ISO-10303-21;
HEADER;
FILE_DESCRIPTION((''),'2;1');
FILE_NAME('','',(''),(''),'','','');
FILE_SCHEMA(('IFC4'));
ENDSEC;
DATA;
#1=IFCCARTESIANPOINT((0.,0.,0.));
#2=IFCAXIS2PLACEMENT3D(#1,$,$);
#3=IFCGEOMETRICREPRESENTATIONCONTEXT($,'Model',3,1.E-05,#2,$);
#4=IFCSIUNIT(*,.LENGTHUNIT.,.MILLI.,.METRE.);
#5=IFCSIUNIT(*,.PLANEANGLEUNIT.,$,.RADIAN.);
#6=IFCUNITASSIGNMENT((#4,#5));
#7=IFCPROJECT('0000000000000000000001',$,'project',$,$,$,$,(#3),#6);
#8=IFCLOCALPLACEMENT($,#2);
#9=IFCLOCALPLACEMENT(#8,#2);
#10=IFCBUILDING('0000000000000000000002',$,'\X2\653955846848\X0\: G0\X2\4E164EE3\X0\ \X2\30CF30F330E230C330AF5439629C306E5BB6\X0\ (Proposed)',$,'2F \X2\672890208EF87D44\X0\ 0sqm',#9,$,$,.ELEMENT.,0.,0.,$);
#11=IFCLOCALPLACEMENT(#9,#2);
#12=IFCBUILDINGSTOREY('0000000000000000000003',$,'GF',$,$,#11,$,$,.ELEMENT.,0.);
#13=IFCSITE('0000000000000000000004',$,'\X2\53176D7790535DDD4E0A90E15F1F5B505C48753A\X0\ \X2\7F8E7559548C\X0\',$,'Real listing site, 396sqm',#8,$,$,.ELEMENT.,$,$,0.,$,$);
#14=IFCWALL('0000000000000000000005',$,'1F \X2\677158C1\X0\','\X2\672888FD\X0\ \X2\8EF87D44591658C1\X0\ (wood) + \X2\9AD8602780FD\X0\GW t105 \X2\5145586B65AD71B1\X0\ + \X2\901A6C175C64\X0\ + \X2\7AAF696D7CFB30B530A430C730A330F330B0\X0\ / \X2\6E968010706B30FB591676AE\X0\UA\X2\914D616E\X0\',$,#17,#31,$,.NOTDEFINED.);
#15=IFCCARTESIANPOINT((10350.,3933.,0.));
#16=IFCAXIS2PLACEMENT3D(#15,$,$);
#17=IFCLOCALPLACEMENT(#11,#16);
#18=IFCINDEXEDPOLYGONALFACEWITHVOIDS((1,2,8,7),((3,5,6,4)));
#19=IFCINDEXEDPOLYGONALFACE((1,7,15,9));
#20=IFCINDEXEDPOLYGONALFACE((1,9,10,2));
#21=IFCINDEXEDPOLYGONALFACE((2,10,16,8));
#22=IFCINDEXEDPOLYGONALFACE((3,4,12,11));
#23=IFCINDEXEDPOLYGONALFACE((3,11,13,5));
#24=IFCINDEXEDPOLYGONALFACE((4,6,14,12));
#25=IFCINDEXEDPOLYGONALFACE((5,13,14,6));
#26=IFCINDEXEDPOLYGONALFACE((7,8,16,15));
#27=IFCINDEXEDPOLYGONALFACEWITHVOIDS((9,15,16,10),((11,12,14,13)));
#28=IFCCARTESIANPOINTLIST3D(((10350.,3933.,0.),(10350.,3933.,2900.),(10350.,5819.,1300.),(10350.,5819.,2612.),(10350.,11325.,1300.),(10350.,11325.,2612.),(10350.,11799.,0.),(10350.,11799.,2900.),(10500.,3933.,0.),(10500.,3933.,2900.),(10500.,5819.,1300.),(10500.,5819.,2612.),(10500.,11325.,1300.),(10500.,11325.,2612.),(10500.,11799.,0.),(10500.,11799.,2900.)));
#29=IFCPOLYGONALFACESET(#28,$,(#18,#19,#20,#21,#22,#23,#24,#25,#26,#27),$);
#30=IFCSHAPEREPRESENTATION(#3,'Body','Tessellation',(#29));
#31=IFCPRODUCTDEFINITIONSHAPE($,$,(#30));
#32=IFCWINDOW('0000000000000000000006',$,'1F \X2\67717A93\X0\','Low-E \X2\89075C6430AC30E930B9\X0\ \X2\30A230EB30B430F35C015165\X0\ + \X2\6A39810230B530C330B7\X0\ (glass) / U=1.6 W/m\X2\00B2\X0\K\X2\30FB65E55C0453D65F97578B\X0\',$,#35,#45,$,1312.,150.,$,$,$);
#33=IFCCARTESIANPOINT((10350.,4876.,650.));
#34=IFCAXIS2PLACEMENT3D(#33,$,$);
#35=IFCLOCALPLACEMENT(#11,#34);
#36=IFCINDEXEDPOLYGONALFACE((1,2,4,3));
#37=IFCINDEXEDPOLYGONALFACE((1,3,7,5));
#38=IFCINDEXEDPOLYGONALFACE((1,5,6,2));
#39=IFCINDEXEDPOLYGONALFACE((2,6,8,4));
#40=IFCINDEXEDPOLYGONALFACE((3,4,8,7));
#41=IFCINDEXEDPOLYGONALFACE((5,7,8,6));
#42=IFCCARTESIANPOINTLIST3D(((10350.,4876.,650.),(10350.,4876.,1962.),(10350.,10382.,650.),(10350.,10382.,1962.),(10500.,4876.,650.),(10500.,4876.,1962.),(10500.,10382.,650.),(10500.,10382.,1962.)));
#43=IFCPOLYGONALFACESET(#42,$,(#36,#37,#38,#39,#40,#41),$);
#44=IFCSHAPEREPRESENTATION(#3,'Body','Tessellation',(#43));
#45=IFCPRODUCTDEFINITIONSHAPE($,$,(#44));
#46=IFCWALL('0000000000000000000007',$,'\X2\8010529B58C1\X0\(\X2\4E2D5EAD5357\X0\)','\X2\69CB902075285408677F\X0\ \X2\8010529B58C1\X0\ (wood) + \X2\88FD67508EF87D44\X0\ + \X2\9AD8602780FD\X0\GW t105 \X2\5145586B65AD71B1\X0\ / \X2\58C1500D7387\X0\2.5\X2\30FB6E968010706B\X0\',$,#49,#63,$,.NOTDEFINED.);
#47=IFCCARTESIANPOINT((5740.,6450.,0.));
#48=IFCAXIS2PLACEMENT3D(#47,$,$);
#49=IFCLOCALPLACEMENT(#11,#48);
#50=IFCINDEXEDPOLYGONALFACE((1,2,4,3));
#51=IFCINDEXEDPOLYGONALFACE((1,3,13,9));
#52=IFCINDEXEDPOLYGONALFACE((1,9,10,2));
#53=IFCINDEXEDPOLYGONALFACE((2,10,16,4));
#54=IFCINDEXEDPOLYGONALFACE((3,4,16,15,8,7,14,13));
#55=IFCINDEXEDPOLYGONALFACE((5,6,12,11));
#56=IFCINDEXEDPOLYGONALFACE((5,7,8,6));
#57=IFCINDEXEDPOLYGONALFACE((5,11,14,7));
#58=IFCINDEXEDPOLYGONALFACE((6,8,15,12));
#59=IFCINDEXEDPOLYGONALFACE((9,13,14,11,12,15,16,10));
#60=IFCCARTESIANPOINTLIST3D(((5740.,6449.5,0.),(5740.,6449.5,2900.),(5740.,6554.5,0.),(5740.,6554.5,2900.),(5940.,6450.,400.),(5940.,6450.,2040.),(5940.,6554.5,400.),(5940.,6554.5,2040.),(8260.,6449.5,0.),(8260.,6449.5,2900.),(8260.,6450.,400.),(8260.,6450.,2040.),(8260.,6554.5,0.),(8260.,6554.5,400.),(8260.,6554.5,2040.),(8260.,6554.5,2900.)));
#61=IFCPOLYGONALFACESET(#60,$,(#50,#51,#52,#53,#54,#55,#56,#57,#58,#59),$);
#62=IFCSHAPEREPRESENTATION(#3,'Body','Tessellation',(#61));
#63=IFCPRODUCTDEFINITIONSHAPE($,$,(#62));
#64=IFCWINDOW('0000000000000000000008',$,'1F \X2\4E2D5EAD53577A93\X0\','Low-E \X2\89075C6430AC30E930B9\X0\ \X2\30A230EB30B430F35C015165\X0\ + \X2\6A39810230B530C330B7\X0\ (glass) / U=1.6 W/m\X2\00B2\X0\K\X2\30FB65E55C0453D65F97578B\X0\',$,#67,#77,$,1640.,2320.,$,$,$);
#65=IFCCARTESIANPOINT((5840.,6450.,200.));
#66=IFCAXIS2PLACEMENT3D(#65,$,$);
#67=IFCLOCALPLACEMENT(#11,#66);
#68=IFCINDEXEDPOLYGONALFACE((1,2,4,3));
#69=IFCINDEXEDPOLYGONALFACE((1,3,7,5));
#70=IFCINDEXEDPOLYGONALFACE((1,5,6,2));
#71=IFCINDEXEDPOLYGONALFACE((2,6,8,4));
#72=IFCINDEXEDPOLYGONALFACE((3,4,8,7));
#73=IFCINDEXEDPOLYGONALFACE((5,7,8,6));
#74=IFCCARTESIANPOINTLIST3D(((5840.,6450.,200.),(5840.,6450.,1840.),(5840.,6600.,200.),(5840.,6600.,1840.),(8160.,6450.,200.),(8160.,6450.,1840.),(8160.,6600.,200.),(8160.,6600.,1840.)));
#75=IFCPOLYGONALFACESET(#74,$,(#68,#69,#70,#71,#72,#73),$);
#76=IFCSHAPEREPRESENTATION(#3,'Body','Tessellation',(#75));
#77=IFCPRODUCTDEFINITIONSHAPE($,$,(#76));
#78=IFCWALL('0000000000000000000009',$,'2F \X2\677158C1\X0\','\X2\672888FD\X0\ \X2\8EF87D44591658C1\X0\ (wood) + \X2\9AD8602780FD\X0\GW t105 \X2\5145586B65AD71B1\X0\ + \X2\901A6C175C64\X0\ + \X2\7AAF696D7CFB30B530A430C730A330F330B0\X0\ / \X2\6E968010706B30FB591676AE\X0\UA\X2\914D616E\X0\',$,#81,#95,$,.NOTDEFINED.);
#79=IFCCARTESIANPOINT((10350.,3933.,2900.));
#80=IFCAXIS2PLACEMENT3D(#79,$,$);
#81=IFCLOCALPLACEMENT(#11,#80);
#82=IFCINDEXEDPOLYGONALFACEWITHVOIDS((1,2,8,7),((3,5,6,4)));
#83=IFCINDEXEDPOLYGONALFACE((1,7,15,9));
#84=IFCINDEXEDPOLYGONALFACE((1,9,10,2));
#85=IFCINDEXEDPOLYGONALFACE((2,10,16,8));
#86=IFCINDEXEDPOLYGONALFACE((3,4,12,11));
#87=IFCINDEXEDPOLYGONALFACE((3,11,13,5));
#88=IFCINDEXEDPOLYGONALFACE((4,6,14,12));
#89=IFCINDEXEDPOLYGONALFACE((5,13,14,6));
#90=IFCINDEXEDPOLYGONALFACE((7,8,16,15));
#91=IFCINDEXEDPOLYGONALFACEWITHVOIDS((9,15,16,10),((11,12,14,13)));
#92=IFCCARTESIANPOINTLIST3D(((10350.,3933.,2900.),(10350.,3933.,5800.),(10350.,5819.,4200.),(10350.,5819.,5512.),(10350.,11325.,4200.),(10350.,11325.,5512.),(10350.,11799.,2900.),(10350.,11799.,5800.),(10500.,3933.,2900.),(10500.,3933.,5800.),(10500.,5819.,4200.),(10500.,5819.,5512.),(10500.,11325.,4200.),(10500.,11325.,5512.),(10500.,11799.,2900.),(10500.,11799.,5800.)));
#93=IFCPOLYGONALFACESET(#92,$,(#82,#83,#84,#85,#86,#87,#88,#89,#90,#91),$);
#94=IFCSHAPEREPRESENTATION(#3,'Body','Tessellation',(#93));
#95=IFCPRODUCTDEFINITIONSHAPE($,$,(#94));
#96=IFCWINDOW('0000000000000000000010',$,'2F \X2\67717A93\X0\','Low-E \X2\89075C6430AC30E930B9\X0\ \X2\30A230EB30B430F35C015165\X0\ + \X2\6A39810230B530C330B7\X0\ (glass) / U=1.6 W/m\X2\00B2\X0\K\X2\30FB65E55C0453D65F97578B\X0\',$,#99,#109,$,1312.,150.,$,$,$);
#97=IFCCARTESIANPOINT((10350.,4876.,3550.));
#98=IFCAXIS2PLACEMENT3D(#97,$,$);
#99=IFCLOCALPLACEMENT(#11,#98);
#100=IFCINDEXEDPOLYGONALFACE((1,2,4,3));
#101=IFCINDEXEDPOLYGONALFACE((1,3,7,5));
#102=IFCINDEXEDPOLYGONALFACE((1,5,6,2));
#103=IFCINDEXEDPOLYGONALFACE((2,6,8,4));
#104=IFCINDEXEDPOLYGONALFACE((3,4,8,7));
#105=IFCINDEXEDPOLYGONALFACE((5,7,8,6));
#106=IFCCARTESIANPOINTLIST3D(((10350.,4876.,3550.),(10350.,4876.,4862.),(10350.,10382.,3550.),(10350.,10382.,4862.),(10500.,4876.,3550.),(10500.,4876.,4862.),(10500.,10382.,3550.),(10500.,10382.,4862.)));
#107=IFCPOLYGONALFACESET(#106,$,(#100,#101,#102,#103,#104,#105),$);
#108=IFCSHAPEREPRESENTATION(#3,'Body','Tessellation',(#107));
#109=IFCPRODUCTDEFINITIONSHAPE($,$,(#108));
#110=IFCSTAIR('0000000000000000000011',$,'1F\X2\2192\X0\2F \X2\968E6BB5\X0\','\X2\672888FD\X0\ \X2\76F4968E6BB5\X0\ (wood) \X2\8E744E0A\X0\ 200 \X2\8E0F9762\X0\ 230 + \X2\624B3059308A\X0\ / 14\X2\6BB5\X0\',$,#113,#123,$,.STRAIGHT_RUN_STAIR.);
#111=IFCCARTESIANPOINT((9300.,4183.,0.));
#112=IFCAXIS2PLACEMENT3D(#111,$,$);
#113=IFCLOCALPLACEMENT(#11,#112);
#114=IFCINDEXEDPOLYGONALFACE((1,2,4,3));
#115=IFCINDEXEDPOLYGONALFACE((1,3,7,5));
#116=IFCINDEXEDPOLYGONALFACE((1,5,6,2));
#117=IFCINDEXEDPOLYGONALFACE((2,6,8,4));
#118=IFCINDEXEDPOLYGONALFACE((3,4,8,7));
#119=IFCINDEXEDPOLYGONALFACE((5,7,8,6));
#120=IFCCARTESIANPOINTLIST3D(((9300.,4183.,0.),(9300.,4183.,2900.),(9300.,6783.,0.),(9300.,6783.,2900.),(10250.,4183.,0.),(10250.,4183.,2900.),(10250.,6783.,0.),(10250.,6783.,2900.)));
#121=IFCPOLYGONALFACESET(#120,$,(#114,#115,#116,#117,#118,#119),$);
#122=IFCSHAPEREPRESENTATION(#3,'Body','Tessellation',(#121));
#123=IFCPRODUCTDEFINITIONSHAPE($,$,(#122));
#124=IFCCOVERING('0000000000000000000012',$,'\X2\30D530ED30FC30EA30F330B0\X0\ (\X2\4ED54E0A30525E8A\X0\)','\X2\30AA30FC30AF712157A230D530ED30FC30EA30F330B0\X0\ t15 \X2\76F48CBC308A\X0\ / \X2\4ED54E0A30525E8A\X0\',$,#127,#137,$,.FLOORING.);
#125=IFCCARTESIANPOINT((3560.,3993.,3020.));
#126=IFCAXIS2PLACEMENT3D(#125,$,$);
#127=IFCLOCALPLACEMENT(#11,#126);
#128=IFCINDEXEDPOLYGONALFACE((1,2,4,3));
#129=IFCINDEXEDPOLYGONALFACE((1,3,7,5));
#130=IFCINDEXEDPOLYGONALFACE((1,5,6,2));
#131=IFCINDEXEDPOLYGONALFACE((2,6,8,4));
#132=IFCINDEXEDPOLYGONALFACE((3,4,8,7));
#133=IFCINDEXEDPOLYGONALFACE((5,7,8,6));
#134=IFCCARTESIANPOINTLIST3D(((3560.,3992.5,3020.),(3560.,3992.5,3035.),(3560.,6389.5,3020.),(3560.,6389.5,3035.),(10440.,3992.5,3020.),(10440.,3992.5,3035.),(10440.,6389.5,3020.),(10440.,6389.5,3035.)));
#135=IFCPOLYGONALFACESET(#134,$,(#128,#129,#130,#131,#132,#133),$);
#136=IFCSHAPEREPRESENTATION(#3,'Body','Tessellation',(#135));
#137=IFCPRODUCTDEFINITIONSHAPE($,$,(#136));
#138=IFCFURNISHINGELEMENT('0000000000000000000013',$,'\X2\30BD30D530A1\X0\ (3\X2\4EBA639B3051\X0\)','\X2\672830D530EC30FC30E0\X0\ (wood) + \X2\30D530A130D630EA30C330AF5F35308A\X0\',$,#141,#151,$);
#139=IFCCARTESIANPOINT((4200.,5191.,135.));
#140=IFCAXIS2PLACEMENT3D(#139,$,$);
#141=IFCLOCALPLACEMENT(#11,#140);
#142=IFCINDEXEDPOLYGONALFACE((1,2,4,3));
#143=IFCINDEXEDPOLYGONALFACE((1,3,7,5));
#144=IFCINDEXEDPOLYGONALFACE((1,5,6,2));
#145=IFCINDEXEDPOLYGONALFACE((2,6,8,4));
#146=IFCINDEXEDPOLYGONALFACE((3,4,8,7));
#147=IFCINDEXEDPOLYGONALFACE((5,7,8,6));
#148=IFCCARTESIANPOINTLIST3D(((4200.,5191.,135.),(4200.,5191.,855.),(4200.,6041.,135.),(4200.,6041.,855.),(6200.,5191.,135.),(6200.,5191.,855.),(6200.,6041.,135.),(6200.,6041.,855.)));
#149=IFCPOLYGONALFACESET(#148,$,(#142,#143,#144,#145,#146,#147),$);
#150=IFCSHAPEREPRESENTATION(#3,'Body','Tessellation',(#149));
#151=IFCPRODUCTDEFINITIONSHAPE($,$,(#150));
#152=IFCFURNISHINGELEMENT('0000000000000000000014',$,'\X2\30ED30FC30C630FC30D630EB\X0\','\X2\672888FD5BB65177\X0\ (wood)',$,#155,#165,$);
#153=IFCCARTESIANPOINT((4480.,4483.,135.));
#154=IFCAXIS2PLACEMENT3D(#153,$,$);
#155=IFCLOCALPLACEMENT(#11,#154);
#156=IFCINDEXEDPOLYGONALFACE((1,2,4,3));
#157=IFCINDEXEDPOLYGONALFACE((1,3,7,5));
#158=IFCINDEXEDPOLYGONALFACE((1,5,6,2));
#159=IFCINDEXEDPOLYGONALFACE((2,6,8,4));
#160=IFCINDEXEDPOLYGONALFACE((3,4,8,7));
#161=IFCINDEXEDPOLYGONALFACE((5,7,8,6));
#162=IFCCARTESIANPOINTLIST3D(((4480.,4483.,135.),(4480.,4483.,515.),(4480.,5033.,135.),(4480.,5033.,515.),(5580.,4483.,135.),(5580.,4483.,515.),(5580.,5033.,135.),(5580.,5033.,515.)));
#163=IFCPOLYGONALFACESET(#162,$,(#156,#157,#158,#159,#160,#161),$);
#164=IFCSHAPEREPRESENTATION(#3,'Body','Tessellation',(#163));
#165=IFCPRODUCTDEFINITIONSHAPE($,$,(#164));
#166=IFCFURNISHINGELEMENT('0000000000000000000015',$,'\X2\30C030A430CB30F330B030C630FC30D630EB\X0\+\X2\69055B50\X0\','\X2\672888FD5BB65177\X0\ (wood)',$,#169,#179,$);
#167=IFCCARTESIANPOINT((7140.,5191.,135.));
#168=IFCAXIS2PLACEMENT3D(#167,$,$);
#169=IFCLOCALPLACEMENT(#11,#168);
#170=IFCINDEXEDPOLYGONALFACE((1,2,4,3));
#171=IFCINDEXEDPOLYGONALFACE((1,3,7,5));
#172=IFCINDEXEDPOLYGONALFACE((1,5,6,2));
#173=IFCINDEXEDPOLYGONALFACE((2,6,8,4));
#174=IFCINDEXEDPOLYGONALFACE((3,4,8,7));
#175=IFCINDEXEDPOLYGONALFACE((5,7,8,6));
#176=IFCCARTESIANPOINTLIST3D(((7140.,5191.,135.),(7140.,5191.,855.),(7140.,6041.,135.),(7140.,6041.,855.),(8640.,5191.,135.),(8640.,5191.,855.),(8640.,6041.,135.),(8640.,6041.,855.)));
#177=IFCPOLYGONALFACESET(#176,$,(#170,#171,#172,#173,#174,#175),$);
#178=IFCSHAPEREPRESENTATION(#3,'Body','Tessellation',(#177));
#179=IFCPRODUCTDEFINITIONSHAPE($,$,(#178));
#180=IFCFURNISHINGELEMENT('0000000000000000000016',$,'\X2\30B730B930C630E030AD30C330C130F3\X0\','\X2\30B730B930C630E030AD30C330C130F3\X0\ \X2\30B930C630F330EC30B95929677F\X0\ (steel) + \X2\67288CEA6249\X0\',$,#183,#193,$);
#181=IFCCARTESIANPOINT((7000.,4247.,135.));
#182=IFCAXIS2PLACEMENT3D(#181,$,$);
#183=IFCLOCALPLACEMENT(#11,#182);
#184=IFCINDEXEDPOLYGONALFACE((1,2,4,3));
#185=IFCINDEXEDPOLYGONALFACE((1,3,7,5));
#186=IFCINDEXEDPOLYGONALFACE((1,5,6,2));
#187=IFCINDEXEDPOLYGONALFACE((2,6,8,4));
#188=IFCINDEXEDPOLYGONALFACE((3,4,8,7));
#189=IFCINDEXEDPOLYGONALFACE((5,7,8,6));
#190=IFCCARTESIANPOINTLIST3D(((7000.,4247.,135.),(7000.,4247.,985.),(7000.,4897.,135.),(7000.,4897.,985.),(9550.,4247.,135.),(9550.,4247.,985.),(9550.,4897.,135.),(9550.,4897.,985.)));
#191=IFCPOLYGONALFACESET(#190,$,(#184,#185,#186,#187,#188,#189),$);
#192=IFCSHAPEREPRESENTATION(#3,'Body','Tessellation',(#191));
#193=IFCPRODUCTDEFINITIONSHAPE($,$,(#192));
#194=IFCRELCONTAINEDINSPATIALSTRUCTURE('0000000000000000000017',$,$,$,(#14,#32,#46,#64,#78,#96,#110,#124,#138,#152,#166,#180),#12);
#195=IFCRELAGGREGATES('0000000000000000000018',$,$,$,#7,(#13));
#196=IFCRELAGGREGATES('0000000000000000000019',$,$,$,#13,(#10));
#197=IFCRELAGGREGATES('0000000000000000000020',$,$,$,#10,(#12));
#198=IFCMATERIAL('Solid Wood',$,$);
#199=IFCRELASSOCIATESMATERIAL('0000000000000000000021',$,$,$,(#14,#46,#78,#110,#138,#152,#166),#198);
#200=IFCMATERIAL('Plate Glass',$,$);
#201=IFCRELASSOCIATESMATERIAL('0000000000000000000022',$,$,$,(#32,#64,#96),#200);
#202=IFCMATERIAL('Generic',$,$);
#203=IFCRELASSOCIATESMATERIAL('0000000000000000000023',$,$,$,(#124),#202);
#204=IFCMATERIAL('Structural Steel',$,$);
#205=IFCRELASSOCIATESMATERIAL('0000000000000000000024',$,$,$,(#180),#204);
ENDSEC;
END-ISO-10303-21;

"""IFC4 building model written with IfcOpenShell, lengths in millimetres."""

from ifc_helpers import new_model, si_unit, frame, frame_2d, origin, place, context, project, spatial, rectangle, extrude, material, element, fill, save


model = new_model("IFC4")

# Units and contexts
model_context = context("Model", 3, precision=1e-05, world=origin())
ifc_project = project(units=[si_unit("LENGTHUNIT", "METRE", prefix="MILLI"), si_unit("PLANEANGLEUNIT", "RADIAN")], contexts=[model_context])

# Site, building, storey
site_placement = place(None, origin())
site = spatial("IfcSite", under=ifc_project, at=site_placement, Name="北海道川上郡弟子屈町 美留和", ObjectType="Real listing site, 396sqm", CompositionType="ELEMENT", RefElevation=0.0)
building_placement = place(site_placement, origin())
building = spatial("IfcBuilding", under=site, at=building_placement, Name="改善案: G0世代 ハンモック吹抜の家 (Proposed)", ObjectType="2F 木造軸組 0sqm", CompositionType="ELEMENT", ElevationOfRefHeight=0.0, ElevationOfTerrain=0.0)
storey_placement = place(building_placement, origin())
storey = spatial("IfcBuildingStorey", under=building, at=storey_placement, Name="GF", CompositionType="ELEMENT", Elevation=0.0)

# Shared definitions
ifc_material_1 = material(Name="Solid Wood")

# Walls, openings, windows
wall_1_placement = place(storey_placement, frame((10350.0, 3933.0, 0.0)))
wall_1 = element("IfcWall", 1, at=wall_1_placement, inside=storey, material=ifc_material_1, Name="1F 東壁", Description="木製 軸組外壁 (wood) + 高性能GW t105 充填断熱 + 通気層 + 窯業系サイディング / 準耐火・外皮UA配慮", PredefinedType="NOTDEFINED", context=model_context, shape_type="SweptSolid", body=[
    extrude(rectangle(XDim=150.0, YDim=7866.0, at=frame_2d((75.0, 3933.0))), frame((10350.0, 3933.0, 0.0)), (0.0, 0.0, 1.0), 2900.0),
])
opening_1_placement = place(storey_placement, frame((10350.0, 4876.0, 650.0)))
opening_1 = element("IfcOpeningElement", 2, at=opening_1_placement, cuts=wall_1, PredefinedType="NOTDEFINED", context=model_context, shape_type="SweptSolid", body=[
    extrude(rectangle(XDim=150.0, YDim=5506.0, at=frame_2d((75.0, 2753.0))), frame((10350.0, 4876.0, 650.0)), (0.0, 0.0, 1.0), 1312.0),
])
ifc_material_2 = material(Name="Plate Glass")
window_1_placement = place(storey_placement, frame((10350.0, 4876.0, 650.0)))
window_1 = element("IfcWindow", 3, at=window_1_placement, inside=storey, material=ifc_material_2, Name="1F 東窓", Description="Low-E 複層ガラス アルゴン封入 + 樹脂サッシ (glass) / U=1.6 W/m²K・日射取得型", OverallHeight=1312.0, OverallWidth=150.0, context=model_context, shape_type="SweptSolid", body=[
    extrude(rectangle(XDim=150.0, YDim=5506.0, at=frame_2d((75.0, 2753.0))), frame((10350.0, 4876.0, 650.0)), (0.0, 0.0, 1.0), 1312.0),
])
fill(opening_1, window_1)
wall_2_placement = place(storey_placement, frame((5740.0, 6450.0, 0.0)))
wall_2 = element("IfcWall", 4, at=wall_2_placement, inside=storey, material=ifc_material_1, Name="耐力壁(中庭南)", Description="構造用合板 耐力壁 (wood) + 製材軸組 + 高性能GW t105 充填断熱 / 壁倍率2.5・準耐火", PredefinedType="NOTDEFINED", context=model_context, shape_type="SweptSolid", body=[
    extrude(rectangle(XDim=2520.0, YDim=105.0, at=frame_2d((1260.0, 52.0))), frame((5740.0, 6450.0, 0.0)), (0.0, 0.0, 1.0), 2900.0),
])
opening_2_placement = place(storey_placement, frame((5840.0, 6450.0, 200.0)))
opening_2 = element("IfcOpeningElement", 5, at=opening_2_placement, cuts=wall_2, PredefinedType="NOTDEFINED", context=model_context, shape_type="SweptSolid", body=[
    extrude(rectangle(XDim=2320.0, YDim=150.0, at=frame_2d((1160.0, 75.0))), frame((5840.0, 6450.0, 200.0)), (0.0, 0.0, 1.0), 1640.0),
])
window_2_placement = place(storey_placement, frame((5840.0, 6450.0, 200.0)))
window_2 = element("IfcWindow", 6, at=window_2_placement, inside=storey, material=ifc_material_2, Name="1F 中庭南窓", Description="Low-E 複層ガラス アルゴン封入 + 樹脂サッシ (glass) / U=1.6 W/m²K・日射取得型", OverallHeight=1640.0, OverallWidth=2320.0, context=model_context, shape_type="SweptSolid", body=[
    extrude(rectangle(XDim=2320.0, YDim=150.0, at=frame_2d((1160.0, 75.0))), frame((5840.0, 6450.0, 200.0)), (0.0, 0.0, 1.0), 1640.0),
])
fill(opening_2, window_2)

# Wall, opening, window
wall_3_placement = place(storey_placement, frame((10350.0, 3933.0, 2900.0)))
wall_3 = element("IfcWall", 7, at=wall_3_placement, inside=storey, material=ifc_material_1, Name="2F 東壁", Description="木製 軸組外壁 (wood) + 高性能GW t105 充填断熱 + 通気層 + 窯業系サイディング / 準耐火・外皮UA配慮", PredefinedType="NOTDEFINED", context=model_context, shape_type="SweptSolid", body=[
    extrude(rectangle(XDim=150.0, YDim=7866.0, at=frame_2d((75.0, 3933.0))), frame((10350.0, 3933.0, 2900.0)), (0.0, 0.0, 1.0), 2900.0),
])
opening_3_placement = place(storey_placement, frame((10350.0, 4876.0, 3550.0)))
opening_3 = element("IfcOpeningElement", 8, at=opening_3_placement, cuts=wall_3, PredefinedType="NOTDEFINED", context=model_context, shape_type="SweptSolid", body=[
    extrude(rectangle(XDim=150.0, YDim=5506.0, at=frame_2d((75.0, 2753.0))), frame((10350.0, 4876.0, 3550.0)), (0.0, 0.0, 1.0), 1312.0),
])
window_3_placement = place(storey_placement, frame((10350.0, 4876.0, 3550.0)))
window_3 = element("IfcWindow", 9, at=window_3_placement, inside=storey, material=ifc_material_2, Name="2F 東窓", Description="Low-E 複層ガラス アルゴン封入 + 樹脂サッシ (glass) / U=1.6 W/m²K・日射取得型", OverallHeight=1312.0, OverallWidth=150.0, context=model_context, shape_type="SweptSolid", body=[
    extrude(rectangle(XDim=150.0, YDim=5506.0, at=frame_2d((75.0, 2753.0))), frame((10350.0, 4876.0, 3550.0)), (0.0, 0.0, 1.0), 1312.0),
])
fill(opening_3, window_3)

# Stair
stair_placement = place(storey_placement, frame((9300.0, 4183.0, 0.0)))
element("IfcStair", 10, at=stair_placement, inside=storey, material=ifc_material_1, Name="1F→2F 階段", Description="木製 直階段 (wood) 蹴上 200 踏面 230 + 手すり / 14段", PredefinedType="STRAIGHT_RUN_STAIR", context=model_context, shape_type="SweptSolid", body=[
    extrude(rectangle(XDim=950.0, YDim=2600.0, at=frame_2d((475.0, 1300.0))), frame((9300.0, 4183.0, 0.0)), (0.0, 0.0, 1.0), 2900.0),
])

# Covering
ifc_material_3 = material(Name="Generic")
covering_placement = place(storey_placement, frame((3560.0, 3993.0, 3020.0)))
element("IfcCovering", 11, at=covering_placement, inside=storey, material=ifc_material_3, Name="フローリング (仕上げ床)", Description="オーク無垢フローリング t15 直貼り / 仕上げ床", PredefinedType="FLOORING", context=model_context, shape_type="SweptSolid", body=[
    extrude(rectangle(XDim=6880.0, YDim=2397.0, at=frame_2d((3440.0, 1198.0))), frame((3560.0, 3993.0, 3020.0)), (0.0, 0.0, 1.0), 15.0),
])

# Furnishing elements
furnishing_1_placement = place(storey_placement, frame((4200.0, 5191.0, 135.0)))
element("IfcFurnishingElement", 12, at=furnishing_1_placement, inside=storey, material=ifc_material_1, Name="ソファ (3人掛け)", Description="木フレーム (wood) + ファブリック張り", context=model_context, shape_type="SweptSolid", body=[
    extrude(rectangle(XDim=2000.0, YDim=850.0, at=frame_2d((1000.0, 425.0))), frame((4200.0, 5191.0, 135.0)), (0.0, 0.0, 1.0), 720.0),
])
furnishing_2_placement = place(storey_placement, frame((4480.0, 4483.0, 135.0)))
element("IfcFurnishingElement", 13, at=furnishing_2_placement, inside=storey, material=ifc_material_1, Name="ローテーブル", Description="木製家具 (wood)", context=model_context, shape_type="SweptSolid", body=[
    extrude(rectangle(XDim=1100.0, YDim=550.0, at=frame_2d((550.0, 275.0))), frame((4480.0, 4483.0, 135.0)), (0.0, 0.0, 1.0), 380.0),
])
furnishing_3_placement = place(storey_placement, frame((7140.0, 5191.0, 135.0)))
element("IfcFurnishingElement", 14, at=furnishing_3_placement, inside=storey, material=ifc_material_1, Name="ダイニングテーブル+椅子", Description="木製家具 (wood)", context=model_context, shape_type="SweptSolid", body=[
    extrude(rectangle(XDim=1500.0, YDim=850.0, at=frame_2d((750.0, 425.0))), frame((7140.0, 5191.0, 135.0)), (0.0, 0.0, 1.0), 720.0),
])
ifc_material_4 = material(Name="Structural Steel")
furnishing_4_placement = place(storey_placement, frame((7000.0, 4247.0, 135.0)))
element("IfcFurnishingElement", 15, at=furnishing_4_placement, inside=storey, material=ifc_material_4, Name="システムキッチン", Description="システムキッチン ステンレス天板 (steel) + 木質扉", context=model_context, shape_type="SweptSolid", body=[
    extrude(rectangle(XDim=2550.0, YDim=650.0, at=frame_2d((1275.0, 325.0))), frame((7000.0, 4247.0, 135.0)), (0.0, 0.0, 1.0), 850.0),
])

save(model, "model.ifc")
